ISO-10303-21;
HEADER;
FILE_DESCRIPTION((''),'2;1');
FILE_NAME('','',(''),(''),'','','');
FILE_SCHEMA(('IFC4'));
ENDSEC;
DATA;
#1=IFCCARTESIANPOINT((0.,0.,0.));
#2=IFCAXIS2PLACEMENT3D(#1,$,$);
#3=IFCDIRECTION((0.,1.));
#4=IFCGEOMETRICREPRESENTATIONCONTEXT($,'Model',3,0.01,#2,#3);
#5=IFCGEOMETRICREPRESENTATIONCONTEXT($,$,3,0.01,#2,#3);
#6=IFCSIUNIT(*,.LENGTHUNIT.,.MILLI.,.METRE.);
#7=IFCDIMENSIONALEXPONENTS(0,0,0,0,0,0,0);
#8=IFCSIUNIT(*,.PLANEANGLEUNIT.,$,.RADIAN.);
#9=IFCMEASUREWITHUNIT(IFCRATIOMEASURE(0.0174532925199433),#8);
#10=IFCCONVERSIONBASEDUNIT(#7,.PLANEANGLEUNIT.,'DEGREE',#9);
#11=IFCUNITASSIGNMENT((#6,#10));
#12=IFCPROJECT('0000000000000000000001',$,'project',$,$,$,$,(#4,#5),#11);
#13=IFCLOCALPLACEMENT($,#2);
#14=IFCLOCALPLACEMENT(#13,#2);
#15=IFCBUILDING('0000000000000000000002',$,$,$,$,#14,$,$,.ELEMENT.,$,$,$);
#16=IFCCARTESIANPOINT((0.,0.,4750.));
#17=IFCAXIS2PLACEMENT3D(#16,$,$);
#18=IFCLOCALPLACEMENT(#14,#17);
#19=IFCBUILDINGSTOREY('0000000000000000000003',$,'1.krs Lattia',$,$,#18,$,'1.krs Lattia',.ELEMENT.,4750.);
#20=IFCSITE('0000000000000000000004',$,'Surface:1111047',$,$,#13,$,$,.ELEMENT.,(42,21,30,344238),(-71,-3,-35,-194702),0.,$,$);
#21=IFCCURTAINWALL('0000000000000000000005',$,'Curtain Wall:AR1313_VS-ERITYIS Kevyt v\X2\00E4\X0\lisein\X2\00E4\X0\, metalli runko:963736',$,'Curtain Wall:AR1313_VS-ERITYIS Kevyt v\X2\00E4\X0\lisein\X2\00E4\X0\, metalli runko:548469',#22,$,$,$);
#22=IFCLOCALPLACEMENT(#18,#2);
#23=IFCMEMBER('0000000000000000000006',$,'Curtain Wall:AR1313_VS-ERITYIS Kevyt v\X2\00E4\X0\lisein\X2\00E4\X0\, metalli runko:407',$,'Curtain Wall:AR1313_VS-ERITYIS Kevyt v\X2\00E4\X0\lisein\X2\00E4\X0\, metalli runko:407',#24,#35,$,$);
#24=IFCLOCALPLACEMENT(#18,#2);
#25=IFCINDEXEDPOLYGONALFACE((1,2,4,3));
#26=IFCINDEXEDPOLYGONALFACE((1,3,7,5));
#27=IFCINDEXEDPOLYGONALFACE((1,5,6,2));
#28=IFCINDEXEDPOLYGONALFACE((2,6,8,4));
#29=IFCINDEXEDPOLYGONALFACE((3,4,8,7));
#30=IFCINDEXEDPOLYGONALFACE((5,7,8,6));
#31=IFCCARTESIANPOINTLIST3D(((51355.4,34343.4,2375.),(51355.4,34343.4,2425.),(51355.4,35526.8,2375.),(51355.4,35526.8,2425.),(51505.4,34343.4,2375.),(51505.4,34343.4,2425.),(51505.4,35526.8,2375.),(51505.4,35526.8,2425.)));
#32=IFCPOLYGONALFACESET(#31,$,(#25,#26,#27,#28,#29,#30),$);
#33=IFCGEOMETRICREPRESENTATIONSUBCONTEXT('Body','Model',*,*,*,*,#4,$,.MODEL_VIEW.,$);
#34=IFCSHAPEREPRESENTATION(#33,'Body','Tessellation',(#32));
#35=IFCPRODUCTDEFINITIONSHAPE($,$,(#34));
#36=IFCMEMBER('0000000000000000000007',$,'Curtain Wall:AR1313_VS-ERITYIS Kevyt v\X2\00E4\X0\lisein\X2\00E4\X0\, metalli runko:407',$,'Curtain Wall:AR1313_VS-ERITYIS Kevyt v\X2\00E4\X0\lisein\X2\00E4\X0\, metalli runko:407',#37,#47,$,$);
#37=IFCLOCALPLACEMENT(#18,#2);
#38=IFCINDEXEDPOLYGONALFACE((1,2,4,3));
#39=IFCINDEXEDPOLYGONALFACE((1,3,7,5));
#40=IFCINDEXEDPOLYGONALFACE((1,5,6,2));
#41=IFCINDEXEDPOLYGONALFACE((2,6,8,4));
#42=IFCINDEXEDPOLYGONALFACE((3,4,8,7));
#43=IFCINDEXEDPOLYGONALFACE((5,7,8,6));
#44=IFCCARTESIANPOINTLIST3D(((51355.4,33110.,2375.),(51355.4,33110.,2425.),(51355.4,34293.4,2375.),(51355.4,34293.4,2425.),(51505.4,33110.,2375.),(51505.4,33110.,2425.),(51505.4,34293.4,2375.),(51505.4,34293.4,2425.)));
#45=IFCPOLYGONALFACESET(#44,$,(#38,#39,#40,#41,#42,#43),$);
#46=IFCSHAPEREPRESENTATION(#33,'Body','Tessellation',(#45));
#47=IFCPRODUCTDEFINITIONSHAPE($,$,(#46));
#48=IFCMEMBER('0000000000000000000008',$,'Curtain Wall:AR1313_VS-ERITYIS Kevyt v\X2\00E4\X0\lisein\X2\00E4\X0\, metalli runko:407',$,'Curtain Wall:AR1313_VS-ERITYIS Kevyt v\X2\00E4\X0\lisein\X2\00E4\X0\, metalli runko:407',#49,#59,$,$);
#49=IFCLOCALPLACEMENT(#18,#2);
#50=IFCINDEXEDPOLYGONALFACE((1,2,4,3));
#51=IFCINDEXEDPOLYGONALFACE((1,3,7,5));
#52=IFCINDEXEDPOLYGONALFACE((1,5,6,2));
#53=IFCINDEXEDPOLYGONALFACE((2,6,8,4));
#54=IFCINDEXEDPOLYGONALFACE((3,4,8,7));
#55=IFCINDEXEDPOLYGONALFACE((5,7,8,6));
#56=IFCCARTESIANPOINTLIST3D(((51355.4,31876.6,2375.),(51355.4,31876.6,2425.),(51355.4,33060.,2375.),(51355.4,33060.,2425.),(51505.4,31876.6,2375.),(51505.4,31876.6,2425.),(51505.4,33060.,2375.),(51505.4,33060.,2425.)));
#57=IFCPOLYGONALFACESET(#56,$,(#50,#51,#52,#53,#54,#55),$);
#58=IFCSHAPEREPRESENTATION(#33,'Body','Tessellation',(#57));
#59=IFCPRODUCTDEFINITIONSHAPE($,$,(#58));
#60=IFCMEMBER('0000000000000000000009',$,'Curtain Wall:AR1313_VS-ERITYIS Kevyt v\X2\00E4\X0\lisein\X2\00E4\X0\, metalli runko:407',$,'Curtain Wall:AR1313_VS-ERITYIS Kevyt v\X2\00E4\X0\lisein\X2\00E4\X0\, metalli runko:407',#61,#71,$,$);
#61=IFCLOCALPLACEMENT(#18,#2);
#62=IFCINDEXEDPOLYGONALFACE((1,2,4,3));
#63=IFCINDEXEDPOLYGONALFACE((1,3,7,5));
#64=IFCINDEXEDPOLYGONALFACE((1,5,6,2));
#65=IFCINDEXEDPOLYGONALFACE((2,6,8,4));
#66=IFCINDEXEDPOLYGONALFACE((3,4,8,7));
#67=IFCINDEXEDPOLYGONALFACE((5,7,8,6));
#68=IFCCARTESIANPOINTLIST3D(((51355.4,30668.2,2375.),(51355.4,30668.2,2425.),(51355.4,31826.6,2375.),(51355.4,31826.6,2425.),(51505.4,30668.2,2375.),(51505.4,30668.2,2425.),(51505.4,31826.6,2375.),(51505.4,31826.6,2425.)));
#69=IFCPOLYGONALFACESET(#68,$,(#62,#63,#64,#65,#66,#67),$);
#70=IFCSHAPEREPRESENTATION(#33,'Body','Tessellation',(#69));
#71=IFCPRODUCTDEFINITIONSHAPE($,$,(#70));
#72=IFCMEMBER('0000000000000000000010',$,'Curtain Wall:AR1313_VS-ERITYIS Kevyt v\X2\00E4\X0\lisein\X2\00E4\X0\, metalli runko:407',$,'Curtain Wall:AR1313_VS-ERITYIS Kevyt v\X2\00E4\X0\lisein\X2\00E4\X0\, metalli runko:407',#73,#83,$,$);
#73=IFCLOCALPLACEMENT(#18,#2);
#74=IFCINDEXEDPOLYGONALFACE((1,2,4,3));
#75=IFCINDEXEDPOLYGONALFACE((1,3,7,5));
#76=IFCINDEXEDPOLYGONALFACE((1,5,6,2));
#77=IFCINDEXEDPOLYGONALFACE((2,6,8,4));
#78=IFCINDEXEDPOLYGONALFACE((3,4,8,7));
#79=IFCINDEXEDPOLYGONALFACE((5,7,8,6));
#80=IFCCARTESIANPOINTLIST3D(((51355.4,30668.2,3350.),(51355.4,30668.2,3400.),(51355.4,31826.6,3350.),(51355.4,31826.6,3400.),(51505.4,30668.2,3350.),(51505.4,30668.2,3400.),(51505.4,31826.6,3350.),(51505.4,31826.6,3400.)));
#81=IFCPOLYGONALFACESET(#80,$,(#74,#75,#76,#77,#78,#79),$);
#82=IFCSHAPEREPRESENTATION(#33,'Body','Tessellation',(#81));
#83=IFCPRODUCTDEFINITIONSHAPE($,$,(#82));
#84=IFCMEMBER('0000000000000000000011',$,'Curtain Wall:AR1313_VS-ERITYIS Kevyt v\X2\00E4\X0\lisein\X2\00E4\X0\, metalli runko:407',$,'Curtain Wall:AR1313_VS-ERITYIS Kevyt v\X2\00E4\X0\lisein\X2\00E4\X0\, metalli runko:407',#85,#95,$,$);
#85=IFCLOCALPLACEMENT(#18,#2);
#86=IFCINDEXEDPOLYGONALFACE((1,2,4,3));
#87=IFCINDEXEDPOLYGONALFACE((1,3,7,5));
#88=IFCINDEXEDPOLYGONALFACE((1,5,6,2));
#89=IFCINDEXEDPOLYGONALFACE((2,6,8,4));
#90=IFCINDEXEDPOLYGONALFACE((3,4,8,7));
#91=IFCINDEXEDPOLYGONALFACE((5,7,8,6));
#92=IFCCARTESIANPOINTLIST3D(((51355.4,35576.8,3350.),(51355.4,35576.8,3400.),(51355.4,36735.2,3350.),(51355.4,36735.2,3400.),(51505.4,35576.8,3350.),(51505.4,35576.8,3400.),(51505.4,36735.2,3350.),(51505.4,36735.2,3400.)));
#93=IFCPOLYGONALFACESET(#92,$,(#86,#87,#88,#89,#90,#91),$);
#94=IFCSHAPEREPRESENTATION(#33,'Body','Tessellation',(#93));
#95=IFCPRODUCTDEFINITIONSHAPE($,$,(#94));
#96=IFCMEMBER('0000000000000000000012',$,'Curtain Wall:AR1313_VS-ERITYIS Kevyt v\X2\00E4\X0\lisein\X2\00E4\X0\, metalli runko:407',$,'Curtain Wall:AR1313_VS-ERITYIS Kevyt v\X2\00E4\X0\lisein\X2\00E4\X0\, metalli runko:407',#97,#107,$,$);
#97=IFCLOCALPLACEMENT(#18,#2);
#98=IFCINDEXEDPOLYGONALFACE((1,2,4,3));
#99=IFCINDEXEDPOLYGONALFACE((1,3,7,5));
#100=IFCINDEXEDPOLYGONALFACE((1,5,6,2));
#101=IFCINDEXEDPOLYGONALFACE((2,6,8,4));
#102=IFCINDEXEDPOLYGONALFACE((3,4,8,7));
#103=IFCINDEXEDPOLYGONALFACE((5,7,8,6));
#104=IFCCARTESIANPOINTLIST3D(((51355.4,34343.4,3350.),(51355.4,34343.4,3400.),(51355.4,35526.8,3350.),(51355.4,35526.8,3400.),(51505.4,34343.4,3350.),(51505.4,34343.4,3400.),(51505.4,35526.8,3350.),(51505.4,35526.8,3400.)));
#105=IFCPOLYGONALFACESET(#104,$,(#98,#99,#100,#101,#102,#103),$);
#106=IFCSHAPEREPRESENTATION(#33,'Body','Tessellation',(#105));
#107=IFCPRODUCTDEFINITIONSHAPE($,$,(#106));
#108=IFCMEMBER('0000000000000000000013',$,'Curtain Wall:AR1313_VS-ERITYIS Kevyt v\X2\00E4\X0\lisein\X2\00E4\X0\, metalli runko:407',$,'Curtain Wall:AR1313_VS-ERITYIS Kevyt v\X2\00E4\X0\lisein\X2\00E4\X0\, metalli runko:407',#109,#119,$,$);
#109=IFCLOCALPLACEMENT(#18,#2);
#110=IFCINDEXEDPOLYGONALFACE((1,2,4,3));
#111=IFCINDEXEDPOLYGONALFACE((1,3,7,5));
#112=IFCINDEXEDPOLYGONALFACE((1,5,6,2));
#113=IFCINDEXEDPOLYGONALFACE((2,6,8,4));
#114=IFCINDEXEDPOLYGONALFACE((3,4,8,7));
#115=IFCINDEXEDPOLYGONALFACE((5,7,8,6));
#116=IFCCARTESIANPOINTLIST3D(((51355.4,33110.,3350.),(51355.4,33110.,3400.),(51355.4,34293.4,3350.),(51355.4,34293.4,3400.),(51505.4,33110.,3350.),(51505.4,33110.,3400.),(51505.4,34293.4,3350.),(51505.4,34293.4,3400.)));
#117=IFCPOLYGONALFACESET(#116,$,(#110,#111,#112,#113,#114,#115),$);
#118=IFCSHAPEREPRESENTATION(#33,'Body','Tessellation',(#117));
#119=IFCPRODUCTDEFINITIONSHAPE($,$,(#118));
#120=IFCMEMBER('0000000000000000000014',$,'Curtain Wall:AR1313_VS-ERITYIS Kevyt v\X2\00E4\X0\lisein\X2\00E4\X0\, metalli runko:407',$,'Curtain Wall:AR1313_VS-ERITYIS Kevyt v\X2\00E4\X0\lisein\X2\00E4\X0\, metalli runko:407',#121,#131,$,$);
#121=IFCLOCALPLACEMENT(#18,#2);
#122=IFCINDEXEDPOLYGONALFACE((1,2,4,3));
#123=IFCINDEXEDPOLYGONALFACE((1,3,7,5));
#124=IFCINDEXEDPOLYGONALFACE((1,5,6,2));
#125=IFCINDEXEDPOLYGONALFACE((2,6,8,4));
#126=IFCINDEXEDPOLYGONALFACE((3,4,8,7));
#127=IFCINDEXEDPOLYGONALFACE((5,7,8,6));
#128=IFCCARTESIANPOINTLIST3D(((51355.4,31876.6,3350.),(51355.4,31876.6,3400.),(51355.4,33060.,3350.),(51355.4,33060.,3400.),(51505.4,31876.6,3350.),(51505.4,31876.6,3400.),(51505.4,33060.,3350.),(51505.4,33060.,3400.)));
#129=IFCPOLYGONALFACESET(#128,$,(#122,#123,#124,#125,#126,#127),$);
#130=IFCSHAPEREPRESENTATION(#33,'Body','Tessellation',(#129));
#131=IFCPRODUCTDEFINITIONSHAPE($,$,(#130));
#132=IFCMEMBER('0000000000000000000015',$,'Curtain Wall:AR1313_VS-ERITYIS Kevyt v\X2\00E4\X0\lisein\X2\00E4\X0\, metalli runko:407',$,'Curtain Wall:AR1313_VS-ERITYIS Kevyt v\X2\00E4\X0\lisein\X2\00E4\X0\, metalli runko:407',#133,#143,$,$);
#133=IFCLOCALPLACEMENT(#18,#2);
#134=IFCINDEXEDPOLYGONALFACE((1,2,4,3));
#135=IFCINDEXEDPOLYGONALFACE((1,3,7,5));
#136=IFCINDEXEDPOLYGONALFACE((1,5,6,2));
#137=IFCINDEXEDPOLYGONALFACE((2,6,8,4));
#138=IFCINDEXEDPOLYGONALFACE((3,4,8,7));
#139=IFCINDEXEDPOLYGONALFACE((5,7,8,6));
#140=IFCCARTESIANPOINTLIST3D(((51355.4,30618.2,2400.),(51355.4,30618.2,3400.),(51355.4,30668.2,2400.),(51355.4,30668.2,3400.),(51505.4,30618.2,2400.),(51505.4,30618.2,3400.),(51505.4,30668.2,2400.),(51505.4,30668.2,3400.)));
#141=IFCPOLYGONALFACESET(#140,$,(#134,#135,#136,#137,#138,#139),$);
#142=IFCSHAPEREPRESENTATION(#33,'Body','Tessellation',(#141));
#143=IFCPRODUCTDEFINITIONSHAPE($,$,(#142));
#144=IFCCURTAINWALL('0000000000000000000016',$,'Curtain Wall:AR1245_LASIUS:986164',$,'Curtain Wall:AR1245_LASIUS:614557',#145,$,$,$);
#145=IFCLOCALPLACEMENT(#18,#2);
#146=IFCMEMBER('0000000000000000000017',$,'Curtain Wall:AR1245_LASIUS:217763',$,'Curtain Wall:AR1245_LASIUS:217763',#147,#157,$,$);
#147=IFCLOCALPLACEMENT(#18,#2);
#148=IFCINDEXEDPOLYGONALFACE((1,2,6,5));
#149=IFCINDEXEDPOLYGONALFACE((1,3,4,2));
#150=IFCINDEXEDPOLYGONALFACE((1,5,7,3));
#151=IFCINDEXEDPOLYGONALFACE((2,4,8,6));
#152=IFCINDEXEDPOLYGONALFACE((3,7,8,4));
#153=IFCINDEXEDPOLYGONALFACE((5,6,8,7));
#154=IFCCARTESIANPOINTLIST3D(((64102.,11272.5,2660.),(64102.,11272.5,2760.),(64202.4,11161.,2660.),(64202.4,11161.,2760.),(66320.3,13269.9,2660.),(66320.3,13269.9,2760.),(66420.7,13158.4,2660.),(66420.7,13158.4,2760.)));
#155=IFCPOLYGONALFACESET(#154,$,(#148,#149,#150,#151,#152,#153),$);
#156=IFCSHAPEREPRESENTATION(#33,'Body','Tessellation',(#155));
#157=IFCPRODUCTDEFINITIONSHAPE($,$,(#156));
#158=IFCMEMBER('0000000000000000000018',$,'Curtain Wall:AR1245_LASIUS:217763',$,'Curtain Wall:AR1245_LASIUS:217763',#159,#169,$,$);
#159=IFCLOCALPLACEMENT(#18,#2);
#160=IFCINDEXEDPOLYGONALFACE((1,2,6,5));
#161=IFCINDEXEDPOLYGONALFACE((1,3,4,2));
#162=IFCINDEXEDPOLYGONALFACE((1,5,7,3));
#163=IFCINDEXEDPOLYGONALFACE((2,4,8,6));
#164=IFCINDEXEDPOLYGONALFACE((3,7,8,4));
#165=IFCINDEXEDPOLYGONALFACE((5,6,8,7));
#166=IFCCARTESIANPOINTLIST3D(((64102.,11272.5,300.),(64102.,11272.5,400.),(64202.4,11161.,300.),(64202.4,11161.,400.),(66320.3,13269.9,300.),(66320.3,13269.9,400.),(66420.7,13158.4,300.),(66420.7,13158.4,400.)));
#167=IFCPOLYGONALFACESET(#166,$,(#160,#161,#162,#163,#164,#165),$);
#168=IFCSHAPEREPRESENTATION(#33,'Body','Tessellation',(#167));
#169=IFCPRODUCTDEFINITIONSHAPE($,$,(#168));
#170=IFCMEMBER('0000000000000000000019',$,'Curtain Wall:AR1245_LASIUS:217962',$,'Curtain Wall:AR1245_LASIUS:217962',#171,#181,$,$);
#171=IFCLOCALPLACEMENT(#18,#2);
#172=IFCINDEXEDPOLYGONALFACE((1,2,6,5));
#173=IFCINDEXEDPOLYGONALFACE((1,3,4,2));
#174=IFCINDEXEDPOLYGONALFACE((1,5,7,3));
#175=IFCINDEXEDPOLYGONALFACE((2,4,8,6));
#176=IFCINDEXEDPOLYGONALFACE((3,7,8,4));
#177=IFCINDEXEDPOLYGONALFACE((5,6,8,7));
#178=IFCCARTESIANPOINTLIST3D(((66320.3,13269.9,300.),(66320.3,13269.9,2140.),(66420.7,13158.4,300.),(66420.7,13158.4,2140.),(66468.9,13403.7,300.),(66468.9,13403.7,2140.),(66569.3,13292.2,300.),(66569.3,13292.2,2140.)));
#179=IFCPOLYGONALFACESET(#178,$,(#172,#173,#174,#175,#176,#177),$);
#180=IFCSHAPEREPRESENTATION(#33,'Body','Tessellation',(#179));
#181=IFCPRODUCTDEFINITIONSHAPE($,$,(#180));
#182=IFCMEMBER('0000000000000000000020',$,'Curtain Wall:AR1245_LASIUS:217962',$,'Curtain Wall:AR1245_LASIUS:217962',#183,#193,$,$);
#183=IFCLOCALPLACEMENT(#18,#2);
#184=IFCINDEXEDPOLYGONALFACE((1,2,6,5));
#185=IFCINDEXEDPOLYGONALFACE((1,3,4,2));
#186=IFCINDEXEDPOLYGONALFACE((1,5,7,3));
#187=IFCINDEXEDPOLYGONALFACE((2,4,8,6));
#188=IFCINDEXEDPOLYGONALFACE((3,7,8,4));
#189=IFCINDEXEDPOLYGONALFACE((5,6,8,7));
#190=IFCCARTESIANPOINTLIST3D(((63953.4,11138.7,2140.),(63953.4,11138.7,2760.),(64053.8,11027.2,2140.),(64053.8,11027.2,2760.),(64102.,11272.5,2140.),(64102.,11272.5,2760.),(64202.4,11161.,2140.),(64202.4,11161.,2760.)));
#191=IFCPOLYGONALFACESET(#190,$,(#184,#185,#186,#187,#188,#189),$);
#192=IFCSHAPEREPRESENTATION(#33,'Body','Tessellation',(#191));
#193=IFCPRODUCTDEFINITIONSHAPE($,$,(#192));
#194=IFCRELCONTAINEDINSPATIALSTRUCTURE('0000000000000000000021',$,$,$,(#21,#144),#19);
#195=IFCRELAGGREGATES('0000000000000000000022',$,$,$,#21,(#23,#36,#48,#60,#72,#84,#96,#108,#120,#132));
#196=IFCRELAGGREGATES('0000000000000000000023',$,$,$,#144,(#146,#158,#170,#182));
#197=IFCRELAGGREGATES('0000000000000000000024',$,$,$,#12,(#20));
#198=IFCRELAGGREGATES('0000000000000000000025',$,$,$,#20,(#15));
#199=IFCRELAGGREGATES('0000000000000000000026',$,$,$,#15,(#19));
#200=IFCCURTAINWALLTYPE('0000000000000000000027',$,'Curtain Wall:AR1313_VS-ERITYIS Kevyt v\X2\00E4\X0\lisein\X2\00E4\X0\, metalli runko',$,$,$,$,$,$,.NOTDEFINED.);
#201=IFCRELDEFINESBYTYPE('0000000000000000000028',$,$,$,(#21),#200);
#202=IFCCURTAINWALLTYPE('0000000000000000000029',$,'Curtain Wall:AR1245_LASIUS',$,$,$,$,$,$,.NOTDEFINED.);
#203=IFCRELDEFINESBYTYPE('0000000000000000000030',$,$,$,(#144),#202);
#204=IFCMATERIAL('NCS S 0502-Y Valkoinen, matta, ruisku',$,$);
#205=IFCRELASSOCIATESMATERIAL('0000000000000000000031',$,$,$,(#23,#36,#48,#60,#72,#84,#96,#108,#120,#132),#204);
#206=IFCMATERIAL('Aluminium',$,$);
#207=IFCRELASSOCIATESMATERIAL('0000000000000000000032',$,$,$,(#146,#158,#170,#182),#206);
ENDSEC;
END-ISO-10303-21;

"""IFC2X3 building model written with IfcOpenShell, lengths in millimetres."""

from ifc_helpers import new_model, entity, si_unit, converted_unit, direction, frame, frame_2d, origin, place, context, subcontext, project, spatial, rectangle, extrude, material, type_object, element, aggregate, save


model = new_model("IFC2X3")

# Units and contexts
model_context = context("Model", 3, precision=0.01, world=origin(), true_north=direction((0.0, 1.0)))
context_of_model = context(None, 3, precision=0.01, world=origin(), true_north=direction((0.0, 1.0)))
body_context = subcontext(model_context, "Body", "Model", "MODEL_VIEW")
ifc_project = project(units=[si_unit("LENGTHUNIT", "METRE", prefix="MILLI"), converted_unit("PLANEANGLEUNIT", "DEGREE", entity("IfcRatioMeasure", 0.0174532925199433), si_unit("PLANEANGLEUNIT", "RADIAN"), dimensions=[0, 0, 0, 0, 0, 0, 0])], contexts=[model_context, context_of_model])

# Site, building, storey
site_placement = place(None, origin())
site = spatial("IfcSite", under=ifc_project, at=site_placement, Name="Surface:1111047", CompositionType="ELEMENT", RefLatitude=(42, 21, 30, 344238), RefLongitude=(-71, -3, -35, -194702), RefElevation=0.0)
building_placement = place(site_placement, origin())
building = spatial("IfcBuilding", under=site, at=building_placement, CompositionType="ELEMENT")
storey_placement = place(building_placement, frame((0.0, 0.0, 4750.0)))
storey = spatial("IfcBuildingStorey", under=building, at=storey_placement, Name="1.krs Lattia", LongName="1.krs Lattia", CompositionType="ELEMENT", Elevation=4750.0)

# Curtain walls, members
curtain_wall_type_1 = type_object("IfcCurtainWallType", Name="Curtain Wall:AR1313_VS-ERITYIS Kevyt väliseinä, metalli runko", PredefinedType="NOTDEFINED")
curtain_wall_1_placement = place(storey_placement, frame((0.0, 0.0, -4750.0)))
curtain_wall_1 = element("IfcCurtainWall", 1, at=curtain_wall_1_placement, inside=storey, type_object=curtain_wall_type_1, Name="Curtain Wall:AR1313_VS-ERITYIS Kevyt väliseinä, metalli runko:963736", ObjectType="Curtain Wall:AR1313_VS-ERITYIS Kevyt väliseinä, metalli runko:548469")
ifc_material_1 = material(Name="NCS S 0502-Y Valkoinen, matta, ruisku")
member_1_placement = place(curtain_wall_1_placement, frame((0.0, 0.0, 4750.0)))
member_1 = element("IfcMember", 2, at=member_1_placement, material=ifc_material_1, Name="Curtain Wall:AR1313_VS-ERITYIS Kevyt väliseinä, metalli runko:407", ObjectType="Curtain Wall:AR1313_VS-ERITYIS Kevyt väliseinä, metalli runko:407", context=body_context, shape_type="SweptSolid", body=[
    extrude(rectangle(XDim=50.0, YDim=150.0, at=frame_2d((0.0, 0.0), x_axis=(1.0, 0.0))), frame((51430.4, 34343.4, 2400.0), z_axis=(0.0, 1.0, 0.0), x_axis=(0.0, 0.0, -1.0)), (0.0, 0.0, 1.0), 1183.4),
])
member_2_placement = place(curtain_wall_1_placement, frame((0.0, 0.0, 4750.0)))
member_2 = element("IfcMember", 3, at=member_2_placement, material=ifc_material_1, Name="Curtain Wall:AR1313_VS-ERITYIS Kevyt väliseinä, metalli runko:407", ObjectType="Curtain Wall:AR1313_VS-ERITYIS Kevyt väliseinä, metalli runko:407", context=body_context, shape_type="SweptSolid", body=[
    extrude(rectangle(XDim=50.0, YDim=150.0, at=frame_2d((0.0, 0.0), x_axis=(1.0, 0.0))), frame((51430.4, 33110.0, 2400.0), z_axis=(0.0, 1.0, 0.0), x_axis=(0.0, 0.0, -1.0)), (0.0, 0.0, 1.0), 1183.4),
])
member_3_placement = place(curtain_wall_1_placement, frame((0.0, 0.0, 4750.0)))
member_3 = element("IfcMember", 4, at=member_3_placement, material=ifc_material_1, Name="Curtain Wall:AR1313_VS-ERITYIS Kevyt väliseinä, metalli runko:407", ObjectType="Curtain Wall:AR1313_VS-ERITYIS Kevyt väliseinä, metalli runko:407", context=body_context, shape_type="SweptSolid", body=[
    extrude(rectangle(XDim=50.0, YDim=150.0, at=frame_2d((0.0, 0.0), x_axis=(1.0, 0.0))), frame((51430.4, 31876.6, 2400.0), z_axis=(0.0, 1.0, 0.0), x_axis=(0.0, 0.0, -1.0)), (0.0, 0.0, 1.0), 1183.4),
])
member_4_placement = place(curtain_wall_1_placement, frame((0.0, 0.0, 4750.0)))
member_4 = element("IfcMember", 5, at=member_4_placement, material=ifc_material_1, Name="Curtain Wall:AR1313_VS-ERITYIS Kevyt väliseinä, metalli runko:407", ObjectType="Curtain Wall:AR1313_VS-ERITYIS Kevyt väliseinä, metalli runko:407", context=body_context, shape_type="SweptSolid", body=[
    extrude(rectangle(XDim=50.0, YDim=150.0, at=frame_2d((0.0, 0.0), x_axis=(1.0, 0.0))), frame((51430.4, 30668.2, 2400.0), z_axis=(0.0, 1.0, 0.0), x_axis=(0.0, 0.0, -1.0)), (0.0, 0.0, 1.0), 1158.4),
])
member_5_placement = place(curtain_wall_1_placement, frame((0.0, 0.0, 4750.0)))
member_5 = element("IfcMember", 6, at=member_5_placement, material=ifc_material_1, Name="Curtain Wall:AR1313_VS-ERITYIS Kevyt väliseinä, metalli runko:407", ObjectType="Curtain Wall:AR1313_VS-ERITYIS Kevyt väliseinä, metalli runko:407", context=body_context, shape_type="SweptSolid", body=[
    extrude(rectangle(XDim=50.0, YDim=150.0, at=frame_2d((0.0, 0.0), x_axis=(1.0, 0.0))), frame((51430.4, 30668.2, 3375.0), z_axis=(0.0, 1.0, 0.0), x_axis=(0.0, 0.0, -1.0)), (0.0, 0.0, 1.0), 1158.4),
])
member_6_placement = place(curtain_wall_1_placement, frame((0.0, 0.0, 4750.0)))
member_6 = element("IfcMember", 7, at=member_6_placement, material=ifc_material_1, Name="Curtain Wall:AR1313_VS-ERITYIS Kevyt väliseinä, metalli runko:407", ObjectType="Curtain Wall:AR1313_VS-ERITYIS Kevyt väliseinä, metalli runko:407", context=body_context, shape_type="SweptSolid", body=[
    extrude(rectangle(XDim=50.0, YDim=150.0, at=frame_2d((0.0, 0.0), x_axis=(1.0, 0.0))), frame((51430.4, 35576.8, 3375.0), z_axis=(0.0, 1.0, 0.0), x_axis=(0.0, 0.0, -1.0)), (0.0, 0.0, 1.0), 1158.4),
])
member_7_placement = place(curtain_wall_1_placement, frame((0.0, 0.0, 4750.0)))
member_7 = element("IfcMember", 8, at=member_7_placement, material=ifc_material_1, Name="Curtain Wall:AR1313_VS-ERITYIS Kevyt väliseinä, metalli runko:407", ObjectType="Curtain Wall:AR1313_VS-ERITYIS Kevyt väliseinä, metalli runko:407", context=body_context, shape_type="SweptSolid", body=[
    extrude(rectangle(XDim=50.0, YDim=150.0, at=frame_2d((0.0, 0.0), x_axis=(1.0, 0.0))), frame((51430.4, 34343.4, 3375.0), z_axis=(0.0, 1.0, 0.0), x_axis=(0.0, 0.0, -1.0)), (0.0, 0.0, 1.0), 1183.4),
])
member_8_placement = place(curtain_wall_1_placement, frame((0.0, 0.0, 4750.0)))
member_8 = element("IfcMember", 9, at=member_8_placement, material=ifc_material_1, Name="Curtain Wall:AR1313_VS-ERITYIS Kevyt väliseinä, metalli runko:407", ObjectType="Curtain Wall:AR1313_VS-ERITYIS Kevyt väliseinä, metalli runko:407", context=body_context, shape_type="SweptSolid", body=[
    extrude(rectangle(XDim=50.0, YDim=150.0, at=frame_2d((0.0, 0.0), x_axis=(1.0, 0.0))), frame((51430.4, 33110.0, 3375.0), z_axis=(0.0, 1.0, 0.0), x_axis=(0.0, 0.0, -1.0)), (0.0, 0.0, 1.0), 1183.4),
])
member_9_placement = place(curtain_wall_1_placement, frame((0.0, 0.0, 4750.0)))
member_9 = element("IfcMember", 10, at=member_9_placement, material=ifc_material_1, Name="Curtain Wall:AR1313_VS-ERITYIS Kevyt väliseinä, metalli runko:407", ObjectType="Curtain Wall:AR1313_VS-ERITYIS Kevyt väliseinä, metalli runko:407", context=body_context, shape_type="SweptSolid", body=[
    extrude(rectangle(XDim=50.0, YDim=150.0, at=frame_2d((0.0, 0.0), x_axis=(1.0, 0.0))), frame((51430.4, 31876.6, 3375.0), z_axis=(0.0, 1.0, 0.0), x_axis=(0.0, 0.0, -1.0)), (0.0, 0.0, 1.0), 1183.4),
])
member_10_placement = place(curtain_wall_1_placement, frame((0.0, 0.0, 4750.0)))
member_10 = element("IfcMember", 11, at=member_10_placement, material=ifc_material_1, Name="Curtain Wall:AR1313_VS-ERITYIS Kevyt väliseinä, metalli runko:407", ObjectType="Curtain Wall:AR1313_VS-ERITYIS Kevyt väliseinä, metalli runko:407", context=body_context, shape_type="SweptSolid", body=[
    extrude(rectangle(XDim=150.0, YDim=50.0, at=frame_2d((0.0, 0.0), x_axis=(1.0, 0.0))), frame((51430.4, 30643.2, 2400.0), z_axis=(0.0, 0.0, 1.0), x_axis=(-1.0, 0.0, 0.0)), (0.0, 0.0, 1.0), 1000.0),
])
aggregate(curtain_wall_1, [member_1, member_2, member_3, member_4, member_5, member_6, member_7, member_8, member_9, member_10])
curtain_wall_type_2 = type_object("IfcCurtainWallType", Name="Curtain Wall:AR1245_LASIUS", PredefinedType="NOTDEFINED")
curtain_wall_2_placement = place(storey_placement, frame((0.0, 0.0, -4750.0)))
curtain_wall_2 = element("IfcCurtainWall", 12, at=curtain_wall_2_placement, inside=storey, type_object=curtain_wall_type_2, Name="Curtain Wall:AR1245_LASIUS:986164", ObjectType="Curtain Wall:AR1245_LASIUS:614557")
ifc_material_2 = material(Name="Aluminium")
member_11_placement = place(curtain_wall_2_placement, frame((0.0, 0.0, 4750.0)))
member_11 = element("IfcMember", 13, at=member_11_placement, material=ifc_material_2, Name="Curtain Wall:AR1245_LASIUS:217763", ObjectType="Curtain Wall:AR1245_LASIUS:217763", context=body_context, shape_type="SweptSolid", body=[
    extrude(rectangle(XDim=100.0, YDim=150.0, at=frame_2d((0.0, 0.0), x_axis=(1.0, 0.0))), frame((66370.5, 13214.1, 2710.0), z_axis=(-0.743145, -0.669131, 0.0), x_axis=(0.0, 0.0, -1.0)), (0.0, 0.0, 1.0), 2985.0),
])
member_12_placement = place(curtain_wall_2_placement, frame((0.0, 0.0, 4750.0)))
member_12 = element("IfcMember", 14, at=member_12_placement, material=ifc_material_2, Name="Curtain Wall:AR1245_LASIUS:217763", ObjectType="Curtain Wall:AR1245_LASIUS:217763", context=body_context, shape_type="SweptSolid", body=[
    extrude(rectangle(XDim=100.0, YDim=150.0, at=frame_2d((0.0, 0.0), x_axis=(1.0, 0.0))), frame((64152.2, 11216.8, 350.0), z_axis=(0.743145, 0.669131, 0.0), x_axis=(0.0, 0.0, -1.0)), (0.0, 0.0, 1.0), 2985.0),
])
member_13_placement = place(curtain_wall_2_placement, frame((0.0, 0.0, 4750.0)))
member_13 = element("IfcMember", 15, at=member_13_placement, material=ifc_material_2, Name="Curtain Wall:AR1245_LASIUS:217962", ObjectType="Curtain Wall:AR1245_LASIUS:217962", context=body_context, shape_type="SweptSolid", body=[
    extrude(rectangle(XDim=200.0, YDim=150.0, at=frame_2d((0.0, 0.0), x_axis=(1.0, 0.0))), frame((66444.8, 13281.0, 300.0), z_axis=(0.0, 0.0, 1.0), x_axis=(0.743145, 0.669131, 0.0)), (0.0, 0.0, 1.0), 1840.0),
])
member_14_placement = place(curtain_wall_2_placement, frame((0.0, 0.0, 4750.0)))
member_14 = element("IfcMember", 16, at=member_14_placement, material=ifc_material_2, Name="Curtain Wall:AR1245_LASIUS:217962", ObjectType="Curtain Wall:AR1245_LASIUS:217962", context=body_context, shape_type="SweptSolid", body=[
    extrude(rectangle(XDim=150.0, YDim=200.0, at=frame_2d((0.0, 0.0), x_axis=(1.0, 0.0))), frame((64077.9, 11149.9, 2760.0), z_axis=(0.0, 0.0, -1.0), x_axis=(0.669131, -0.743145, 0.0)), (0.0, 0.0, 1.0), 620.0),
])
aggregate(curtain_wall_2, [member_11, member_12, member_13, member_14])

save(model, "model.ifc")
